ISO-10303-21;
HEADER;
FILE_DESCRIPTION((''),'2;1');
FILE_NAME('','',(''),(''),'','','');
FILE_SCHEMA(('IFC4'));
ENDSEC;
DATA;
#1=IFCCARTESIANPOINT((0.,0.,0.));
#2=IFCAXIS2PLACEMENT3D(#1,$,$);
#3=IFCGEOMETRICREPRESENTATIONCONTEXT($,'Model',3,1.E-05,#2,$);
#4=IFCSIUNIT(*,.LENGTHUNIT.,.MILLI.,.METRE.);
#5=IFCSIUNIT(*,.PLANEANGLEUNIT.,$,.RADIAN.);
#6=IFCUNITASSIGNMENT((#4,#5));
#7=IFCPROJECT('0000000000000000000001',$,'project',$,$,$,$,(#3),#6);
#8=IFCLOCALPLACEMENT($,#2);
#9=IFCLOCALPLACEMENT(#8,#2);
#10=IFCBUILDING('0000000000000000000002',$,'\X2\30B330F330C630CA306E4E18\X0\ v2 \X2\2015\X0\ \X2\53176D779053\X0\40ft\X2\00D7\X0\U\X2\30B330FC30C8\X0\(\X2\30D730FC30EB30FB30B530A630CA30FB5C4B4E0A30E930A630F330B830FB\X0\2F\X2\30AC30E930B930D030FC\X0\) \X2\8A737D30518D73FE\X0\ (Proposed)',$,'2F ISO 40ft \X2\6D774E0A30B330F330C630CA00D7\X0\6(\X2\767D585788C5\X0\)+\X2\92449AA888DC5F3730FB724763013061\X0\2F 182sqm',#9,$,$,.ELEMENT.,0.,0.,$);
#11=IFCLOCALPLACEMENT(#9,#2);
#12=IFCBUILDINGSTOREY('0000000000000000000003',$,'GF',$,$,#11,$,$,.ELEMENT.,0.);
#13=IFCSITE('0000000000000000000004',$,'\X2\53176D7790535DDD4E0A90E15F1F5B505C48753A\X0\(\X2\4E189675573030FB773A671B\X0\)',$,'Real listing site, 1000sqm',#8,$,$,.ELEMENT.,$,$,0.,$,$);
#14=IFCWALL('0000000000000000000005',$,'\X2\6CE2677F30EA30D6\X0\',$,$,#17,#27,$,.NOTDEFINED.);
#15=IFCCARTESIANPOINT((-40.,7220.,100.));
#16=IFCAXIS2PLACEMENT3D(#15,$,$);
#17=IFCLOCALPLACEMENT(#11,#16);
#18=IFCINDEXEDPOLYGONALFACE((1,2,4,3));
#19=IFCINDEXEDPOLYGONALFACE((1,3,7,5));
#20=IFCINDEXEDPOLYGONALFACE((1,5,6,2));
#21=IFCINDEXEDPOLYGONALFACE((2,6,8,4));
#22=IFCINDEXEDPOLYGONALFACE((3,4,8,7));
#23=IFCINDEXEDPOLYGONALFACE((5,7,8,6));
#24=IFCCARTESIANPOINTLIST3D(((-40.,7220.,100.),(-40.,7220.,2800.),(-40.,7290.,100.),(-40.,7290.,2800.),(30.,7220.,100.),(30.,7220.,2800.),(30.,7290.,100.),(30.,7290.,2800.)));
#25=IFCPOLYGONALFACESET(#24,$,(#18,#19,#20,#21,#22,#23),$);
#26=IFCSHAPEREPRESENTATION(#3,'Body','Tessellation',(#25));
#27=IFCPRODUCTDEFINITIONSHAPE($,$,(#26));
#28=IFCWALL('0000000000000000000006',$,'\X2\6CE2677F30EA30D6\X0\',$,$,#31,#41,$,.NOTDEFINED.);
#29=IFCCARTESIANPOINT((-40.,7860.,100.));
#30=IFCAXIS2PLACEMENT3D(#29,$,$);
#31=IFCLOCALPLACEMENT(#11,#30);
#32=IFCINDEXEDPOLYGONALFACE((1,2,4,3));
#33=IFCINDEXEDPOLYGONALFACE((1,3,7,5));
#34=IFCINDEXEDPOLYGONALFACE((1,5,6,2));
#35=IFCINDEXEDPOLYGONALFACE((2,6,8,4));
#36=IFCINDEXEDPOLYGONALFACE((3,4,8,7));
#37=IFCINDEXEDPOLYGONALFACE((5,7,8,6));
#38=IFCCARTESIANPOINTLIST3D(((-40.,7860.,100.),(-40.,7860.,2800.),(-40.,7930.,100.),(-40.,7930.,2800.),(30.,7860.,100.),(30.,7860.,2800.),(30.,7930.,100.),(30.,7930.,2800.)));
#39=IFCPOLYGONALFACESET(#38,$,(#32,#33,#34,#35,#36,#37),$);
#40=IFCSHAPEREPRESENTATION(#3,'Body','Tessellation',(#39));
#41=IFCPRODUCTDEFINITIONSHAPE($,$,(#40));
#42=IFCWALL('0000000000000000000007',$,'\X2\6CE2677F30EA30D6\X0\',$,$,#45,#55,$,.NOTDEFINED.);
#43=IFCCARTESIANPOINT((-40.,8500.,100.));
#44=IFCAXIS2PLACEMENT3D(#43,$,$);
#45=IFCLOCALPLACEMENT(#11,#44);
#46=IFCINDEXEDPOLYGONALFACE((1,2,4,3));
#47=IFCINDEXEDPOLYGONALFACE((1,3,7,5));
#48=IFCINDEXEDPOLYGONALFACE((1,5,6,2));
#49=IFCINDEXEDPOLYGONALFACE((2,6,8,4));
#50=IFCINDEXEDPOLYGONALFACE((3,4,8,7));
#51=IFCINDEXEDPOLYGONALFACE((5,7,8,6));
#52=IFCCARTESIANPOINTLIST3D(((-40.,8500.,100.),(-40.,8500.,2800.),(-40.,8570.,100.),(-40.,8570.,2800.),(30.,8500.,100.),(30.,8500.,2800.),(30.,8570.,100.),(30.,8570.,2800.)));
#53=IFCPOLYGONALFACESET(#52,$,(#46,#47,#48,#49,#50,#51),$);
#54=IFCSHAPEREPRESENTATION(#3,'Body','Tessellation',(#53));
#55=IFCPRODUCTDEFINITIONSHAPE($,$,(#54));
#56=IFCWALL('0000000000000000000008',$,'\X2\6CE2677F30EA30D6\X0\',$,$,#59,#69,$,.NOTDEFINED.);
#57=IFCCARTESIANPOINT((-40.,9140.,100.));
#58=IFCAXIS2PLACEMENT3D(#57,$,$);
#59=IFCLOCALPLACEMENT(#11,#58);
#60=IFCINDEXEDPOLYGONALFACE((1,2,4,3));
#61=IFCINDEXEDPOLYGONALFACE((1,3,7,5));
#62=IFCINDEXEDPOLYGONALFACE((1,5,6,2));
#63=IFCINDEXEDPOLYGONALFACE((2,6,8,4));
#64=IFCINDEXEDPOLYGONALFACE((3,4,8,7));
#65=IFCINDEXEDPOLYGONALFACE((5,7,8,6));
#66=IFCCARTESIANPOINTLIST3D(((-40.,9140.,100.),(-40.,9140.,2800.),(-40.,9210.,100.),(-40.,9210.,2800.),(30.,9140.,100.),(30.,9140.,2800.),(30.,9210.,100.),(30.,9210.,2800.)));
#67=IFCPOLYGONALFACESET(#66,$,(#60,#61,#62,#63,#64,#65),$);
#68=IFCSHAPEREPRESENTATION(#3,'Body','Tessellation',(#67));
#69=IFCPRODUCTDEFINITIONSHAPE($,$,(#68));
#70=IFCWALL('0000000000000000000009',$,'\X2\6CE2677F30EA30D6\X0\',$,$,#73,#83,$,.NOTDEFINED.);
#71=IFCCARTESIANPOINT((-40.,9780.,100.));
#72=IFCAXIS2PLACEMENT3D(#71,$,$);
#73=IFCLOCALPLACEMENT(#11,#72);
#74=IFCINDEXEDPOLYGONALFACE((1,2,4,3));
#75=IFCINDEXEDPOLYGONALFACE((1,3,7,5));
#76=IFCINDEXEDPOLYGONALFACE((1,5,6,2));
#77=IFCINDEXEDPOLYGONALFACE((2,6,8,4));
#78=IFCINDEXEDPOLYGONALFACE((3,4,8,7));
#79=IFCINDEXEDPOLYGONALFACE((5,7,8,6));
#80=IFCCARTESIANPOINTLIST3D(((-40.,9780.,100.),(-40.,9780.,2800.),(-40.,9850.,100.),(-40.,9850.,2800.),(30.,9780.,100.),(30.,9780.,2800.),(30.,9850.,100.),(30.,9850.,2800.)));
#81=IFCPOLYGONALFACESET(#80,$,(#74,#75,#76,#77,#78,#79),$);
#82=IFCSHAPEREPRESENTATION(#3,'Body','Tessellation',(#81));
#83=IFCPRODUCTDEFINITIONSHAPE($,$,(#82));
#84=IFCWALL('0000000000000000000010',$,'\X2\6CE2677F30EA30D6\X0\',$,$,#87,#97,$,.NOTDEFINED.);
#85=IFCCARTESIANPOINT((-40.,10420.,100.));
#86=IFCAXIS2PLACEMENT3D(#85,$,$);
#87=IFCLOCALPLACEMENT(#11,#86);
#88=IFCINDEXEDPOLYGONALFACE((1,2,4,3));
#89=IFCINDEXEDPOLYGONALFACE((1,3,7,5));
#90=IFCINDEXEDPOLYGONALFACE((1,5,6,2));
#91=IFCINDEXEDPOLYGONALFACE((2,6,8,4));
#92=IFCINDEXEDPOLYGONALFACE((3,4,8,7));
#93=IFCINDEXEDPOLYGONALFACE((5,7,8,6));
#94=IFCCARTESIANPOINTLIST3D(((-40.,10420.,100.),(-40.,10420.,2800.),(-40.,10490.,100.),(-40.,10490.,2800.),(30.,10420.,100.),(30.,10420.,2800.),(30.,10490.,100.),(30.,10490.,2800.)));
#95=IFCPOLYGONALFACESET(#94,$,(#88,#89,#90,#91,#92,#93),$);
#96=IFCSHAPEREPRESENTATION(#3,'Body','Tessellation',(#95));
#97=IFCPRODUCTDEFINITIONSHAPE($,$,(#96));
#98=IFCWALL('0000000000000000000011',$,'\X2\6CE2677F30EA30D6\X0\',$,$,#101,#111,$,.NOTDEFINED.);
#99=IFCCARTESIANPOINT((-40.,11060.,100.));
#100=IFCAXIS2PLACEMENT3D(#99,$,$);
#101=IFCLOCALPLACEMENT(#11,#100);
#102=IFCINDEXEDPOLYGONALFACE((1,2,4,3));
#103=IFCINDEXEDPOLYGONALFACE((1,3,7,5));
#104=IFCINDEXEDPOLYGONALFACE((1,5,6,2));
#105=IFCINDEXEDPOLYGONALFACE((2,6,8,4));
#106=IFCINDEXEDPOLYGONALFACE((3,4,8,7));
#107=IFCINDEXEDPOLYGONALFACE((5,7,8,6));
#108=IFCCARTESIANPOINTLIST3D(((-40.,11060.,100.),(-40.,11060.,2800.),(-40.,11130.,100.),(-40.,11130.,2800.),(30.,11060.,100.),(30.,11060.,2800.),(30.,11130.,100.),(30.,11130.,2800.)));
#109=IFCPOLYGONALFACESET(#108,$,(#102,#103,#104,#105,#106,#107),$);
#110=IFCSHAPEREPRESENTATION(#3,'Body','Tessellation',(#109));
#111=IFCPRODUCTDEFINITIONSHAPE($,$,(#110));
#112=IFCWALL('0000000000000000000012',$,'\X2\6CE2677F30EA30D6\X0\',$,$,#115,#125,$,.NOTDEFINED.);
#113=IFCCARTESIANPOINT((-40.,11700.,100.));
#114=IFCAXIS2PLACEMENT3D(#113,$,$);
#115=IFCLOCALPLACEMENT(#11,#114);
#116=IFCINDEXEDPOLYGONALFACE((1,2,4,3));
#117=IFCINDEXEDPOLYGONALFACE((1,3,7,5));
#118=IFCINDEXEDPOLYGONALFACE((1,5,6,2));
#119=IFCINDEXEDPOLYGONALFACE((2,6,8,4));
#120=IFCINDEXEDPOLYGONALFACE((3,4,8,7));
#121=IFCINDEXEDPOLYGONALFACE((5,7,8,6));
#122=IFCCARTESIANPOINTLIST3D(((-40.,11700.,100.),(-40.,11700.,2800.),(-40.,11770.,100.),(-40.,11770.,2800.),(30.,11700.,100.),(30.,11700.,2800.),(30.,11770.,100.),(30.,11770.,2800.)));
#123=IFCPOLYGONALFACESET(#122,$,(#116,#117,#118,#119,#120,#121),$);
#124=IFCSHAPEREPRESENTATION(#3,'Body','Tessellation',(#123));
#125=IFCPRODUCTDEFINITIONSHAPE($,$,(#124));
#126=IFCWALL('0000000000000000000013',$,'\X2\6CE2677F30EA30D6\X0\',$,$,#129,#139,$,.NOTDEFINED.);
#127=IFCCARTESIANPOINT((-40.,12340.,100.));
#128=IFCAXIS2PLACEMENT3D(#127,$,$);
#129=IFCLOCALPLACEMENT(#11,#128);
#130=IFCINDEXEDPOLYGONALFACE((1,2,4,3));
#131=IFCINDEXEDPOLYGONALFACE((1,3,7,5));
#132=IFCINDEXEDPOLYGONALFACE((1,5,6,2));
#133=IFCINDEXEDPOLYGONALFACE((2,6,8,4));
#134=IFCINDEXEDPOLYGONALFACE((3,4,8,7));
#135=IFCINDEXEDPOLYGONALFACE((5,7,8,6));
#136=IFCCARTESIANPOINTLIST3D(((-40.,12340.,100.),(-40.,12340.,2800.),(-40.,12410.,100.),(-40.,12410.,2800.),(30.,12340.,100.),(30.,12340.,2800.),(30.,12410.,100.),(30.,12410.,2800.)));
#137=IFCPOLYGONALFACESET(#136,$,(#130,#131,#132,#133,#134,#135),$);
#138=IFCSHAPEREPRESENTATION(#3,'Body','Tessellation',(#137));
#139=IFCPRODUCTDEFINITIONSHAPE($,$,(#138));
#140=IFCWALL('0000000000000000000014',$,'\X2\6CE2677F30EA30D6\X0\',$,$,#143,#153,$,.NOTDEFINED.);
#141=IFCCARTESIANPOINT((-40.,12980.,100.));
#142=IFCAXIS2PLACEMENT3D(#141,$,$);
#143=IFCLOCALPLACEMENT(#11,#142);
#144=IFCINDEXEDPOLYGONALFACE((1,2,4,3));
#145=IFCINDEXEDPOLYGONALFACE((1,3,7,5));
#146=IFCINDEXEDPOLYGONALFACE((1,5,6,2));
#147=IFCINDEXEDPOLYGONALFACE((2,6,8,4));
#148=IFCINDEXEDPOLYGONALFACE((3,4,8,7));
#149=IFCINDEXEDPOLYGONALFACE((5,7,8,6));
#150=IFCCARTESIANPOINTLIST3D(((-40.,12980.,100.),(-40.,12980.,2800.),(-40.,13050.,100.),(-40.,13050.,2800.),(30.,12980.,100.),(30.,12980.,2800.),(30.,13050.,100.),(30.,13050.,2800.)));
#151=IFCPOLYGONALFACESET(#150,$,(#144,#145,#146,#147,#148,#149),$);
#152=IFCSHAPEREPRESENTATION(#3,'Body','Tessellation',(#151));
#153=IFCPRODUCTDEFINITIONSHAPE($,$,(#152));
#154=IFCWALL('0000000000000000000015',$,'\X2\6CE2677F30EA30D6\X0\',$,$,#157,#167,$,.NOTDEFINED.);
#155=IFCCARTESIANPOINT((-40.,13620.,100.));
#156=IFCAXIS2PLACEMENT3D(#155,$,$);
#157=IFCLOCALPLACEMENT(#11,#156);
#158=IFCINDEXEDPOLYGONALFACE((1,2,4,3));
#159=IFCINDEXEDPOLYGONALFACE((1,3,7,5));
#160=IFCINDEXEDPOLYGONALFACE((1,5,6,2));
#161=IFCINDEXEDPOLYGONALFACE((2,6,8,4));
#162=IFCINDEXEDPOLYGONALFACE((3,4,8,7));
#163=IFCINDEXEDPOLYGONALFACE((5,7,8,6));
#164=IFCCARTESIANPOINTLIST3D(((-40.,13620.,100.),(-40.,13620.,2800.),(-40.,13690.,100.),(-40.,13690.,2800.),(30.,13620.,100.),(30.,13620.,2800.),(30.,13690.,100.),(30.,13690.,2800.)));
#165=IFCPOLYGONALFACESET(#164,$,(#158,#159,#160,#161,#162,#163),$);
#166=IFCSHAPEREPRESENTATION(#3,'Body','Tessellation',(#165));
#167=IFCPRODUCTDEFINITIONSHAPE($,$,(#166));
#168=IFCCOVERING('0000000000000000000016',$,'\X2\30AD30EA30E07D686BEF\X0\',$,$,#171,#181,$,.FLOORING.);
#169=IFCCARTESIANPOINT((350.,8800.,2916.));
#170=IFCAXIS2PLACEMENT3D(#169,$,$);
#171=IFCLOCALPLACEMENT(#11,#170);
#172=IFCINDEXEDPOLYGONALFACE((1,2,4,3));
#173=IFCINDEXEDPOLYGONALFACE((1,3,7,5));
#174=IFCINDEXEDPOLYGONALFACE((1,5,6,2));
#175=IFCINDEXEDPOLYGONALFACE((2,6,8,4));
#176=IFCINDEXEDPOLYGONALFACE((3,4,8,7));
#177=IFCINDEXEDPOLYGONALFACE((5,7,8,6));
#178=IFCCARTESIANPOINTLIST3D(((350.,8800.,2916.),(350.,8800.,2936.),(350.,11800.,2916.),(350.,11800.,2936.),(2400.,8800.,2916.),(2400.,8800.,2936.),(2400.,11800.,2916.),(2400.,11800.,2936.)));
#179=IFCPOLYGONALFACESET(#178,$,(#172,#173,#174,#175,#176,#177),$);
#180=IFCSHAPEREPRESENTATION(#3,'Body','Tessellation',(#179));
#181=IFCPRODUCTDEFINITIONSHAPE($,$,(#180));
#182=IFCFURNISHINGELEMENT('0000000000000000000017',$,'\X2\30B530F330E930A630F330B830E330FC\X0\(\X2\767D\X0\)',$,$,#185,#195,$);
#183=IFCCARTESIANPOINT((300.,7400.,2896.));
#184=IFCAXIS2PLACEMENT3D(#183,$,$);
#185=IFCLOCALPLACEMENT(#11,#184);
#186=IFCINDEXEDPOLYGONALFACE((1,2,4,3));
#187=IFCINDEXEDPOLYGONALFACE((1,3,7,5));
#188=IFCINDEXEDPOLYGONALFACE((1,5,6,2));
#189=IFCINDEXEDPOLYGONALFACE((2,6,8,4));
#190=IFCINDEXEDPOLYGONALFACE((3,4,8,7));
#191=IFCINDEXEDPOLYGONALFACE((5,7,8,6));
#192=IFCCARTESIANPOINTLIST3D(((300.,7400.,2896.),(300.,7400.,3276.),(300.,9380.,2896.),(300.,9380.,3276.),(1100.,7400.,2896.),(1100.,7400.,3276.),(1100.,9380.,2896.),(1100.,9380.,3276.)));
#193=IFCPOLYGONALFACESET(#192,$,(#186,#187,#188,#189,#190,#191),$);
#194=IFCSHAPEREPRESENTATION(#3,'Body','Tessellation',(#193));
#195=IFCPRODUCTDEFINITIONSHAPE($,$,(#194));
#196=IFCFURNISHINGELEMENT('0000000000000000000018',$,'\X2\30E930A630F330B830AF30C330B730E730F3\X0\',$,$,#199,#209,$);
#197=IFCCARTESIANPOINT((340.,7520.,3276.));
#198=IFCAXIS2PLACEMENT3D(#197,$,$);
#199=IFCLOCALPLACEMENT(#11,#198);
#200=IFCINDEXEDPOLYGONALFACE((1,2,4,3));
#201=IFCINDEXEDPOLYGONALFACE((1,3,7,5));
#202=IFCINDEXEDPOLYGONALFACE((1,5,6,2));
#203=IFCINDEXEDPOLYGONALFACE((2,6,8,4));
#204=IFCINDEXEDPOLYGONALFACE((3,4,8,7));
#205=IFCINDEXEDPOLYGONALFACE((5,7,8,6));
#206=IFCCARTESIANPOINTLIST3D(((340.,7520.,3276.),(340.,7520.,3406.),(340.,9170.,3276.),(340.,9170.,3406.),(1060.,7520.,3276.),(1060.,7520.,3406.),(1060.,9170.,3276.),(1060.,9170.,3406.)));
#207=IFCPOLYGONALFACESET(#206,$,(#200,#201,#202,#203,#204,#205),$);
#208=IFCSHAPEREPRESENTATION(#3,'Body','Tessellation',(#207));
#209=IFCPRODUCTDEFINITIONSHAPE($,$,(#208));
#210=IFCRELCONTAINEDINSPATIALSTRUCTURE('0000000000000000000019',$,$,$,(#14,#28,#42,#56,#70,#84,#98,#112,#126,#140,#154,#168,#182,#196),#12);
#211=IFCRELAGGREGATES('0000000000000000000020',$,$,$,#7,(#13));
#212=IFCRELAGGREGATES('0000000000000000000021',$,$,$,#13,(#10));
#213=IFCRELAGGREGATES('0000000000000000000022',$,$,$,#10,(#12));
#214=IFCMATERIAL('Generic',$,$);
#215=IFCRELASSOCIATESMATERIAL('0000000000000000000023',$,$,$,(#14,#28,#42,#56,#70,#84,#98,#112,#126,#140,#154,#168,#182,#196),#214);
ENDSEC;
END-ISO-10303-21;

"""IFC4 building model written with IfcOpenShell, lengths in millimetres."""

from ifc_helpers import new_model, si_unit, frame, frame_2d, origin, place, context, project, spatial, rectangle, extrude, material, element, save


model = new_model("IFC4")

# Units and contexts
model_context = context("Model", 3, precision=1e-05, world=origin())
ifc_project = project(units=[si_unit("LENGTHUNIT", "METRE", prefix="MILLI"), si_unit("PLANEANGLEUNIT", "RADIAN")], contexts=[model_context])

# Site, building, storey
site_placement = place(None, origin())
site = spatial("IfcSite", under=ifc_project, at=site_placement, Name="北海道川上郡弟子屈町(丘陵地・眺望)", ObjectType="Real listing site, 1000sqm", CompositionType="ELEMENT", RefElevation=0.0)
building_placement = place(site_placement, origin())
building = spatial("IfcBuilding", under=site, at=building_placement, Name="コンテナの丘 v2 ― 北海道40ft×Uコート(プール・サウナ・屋上ラウンジ・2Fガラスバー) 詳細再現 (Proposed)", ObjectType="2F ISO 40ft 海上コンテナ×6(白塗装)+鉄骨補強・片持ち2F 182sqm", CompositionType="ELEMENT", ElevationOfRefHeight=0.0, ElevationOfTerrain=0.0)
storey_placement = place(building_placement, origin())
storey = spatial("IfcBuildingStorey", under=building, at=storey_placement, Name="GF", CompositionType="ELEMENT", Elevation=0.0)

# Walls
ifc_material = material(Name="Generic")
wall_1_placement = place(storey_placement, frame((-40.0, 7220.0, 100.0)))
element("IfcWall", 1, at=wall_1_placement, inside=storey, material=ifc_material, Name="波板リブ", PredefinedType="NOTDEFINED", context=model_context, shape_type="SweptSolid", body=[
    extrude(rectangle(XDim=70.0, YDim=70.0, at=frame_2d((35.0, 35.0))), frame((-40.0, 7220.0, 100.0)), (0.0, 0.0, 1.0), 2700.0),
])
wall_2_placement = place(storey_placement, frame((-40.0, 7860.0, 100.0)))
element("IfcWall", 2, at=wall_2_placement, inside=storey, material=ifc_material, Name="波板リブ", PredefinedType="NOTDEFINED", context=model_context, shape_type="SweptSolid", body=[
    extrude(rectangle(XDim=70.0, YDim=70.0, at=frame_2d((35.0, 35.0))), frame((-40.0, 7860.0, 100.0)), (0.0, 0.0, 1.0), 2700.0),
])
wall_3_placement = place(storey_placement, frame((-40.0, 8500.0, 100.0)))
element("IfcWall", 3, at=wall_3_placement, inside=storey, material=ifc_material, Name="波板リブ", PredefinedType="NOTDEFINED", context=model_context, shape_type="SweptSolid", body=[
    extrude(rectangle(XDim=70.0, YDim=70.0, at=frame_2d((35.0, 35.0))), frame((-40.0, 8500.0, 100.0)), (0.0, 0.0, 1.0), 2700.0),
])
wall_4_placement = place(storey_placement, frame((-40.0, 9140.0, 100.0)))
element("IfcWall", 4, at=wall_4_placement, inside=storey, material=ifc_material, Name="波板リブ", PredefinedType="NOTDEFINED", context=model_context, shape_type="SweptSolid", body=[
    extrude(rectangle(XDim=70.0, YDim=70.0, at=frame_2d((35.0, 35.0))), frame((-40.0, 9140.0, 100.0)), (0.0, 0.0, 1.0), 2700.0),
])
wall_5_placement = place(storey_placement, frame((-40.0, 9780.0, 100.0)))
element("IfcWall", 5, at=wall_5_placement, inside=storey, material=ifc_material, Name="波板リブ", PredefinedType="NOTDEFINED", context=model_context, shape_type="SweptSolid", body=[
    extrude(rectangle(XDim=70.0, YDim=70.0, at=frame_2d((35.0, 35.0))), frame((-40.0, 9780.0, 100.0)), (0.0, 0.0, 1.0), 2700.0),
])
wall_6_placement = place(storey_placement, frame((-40.0, 10420.0, 100.0)))
element("IfcWall", 6, at=wall_6_placement, inside=storey, material=ifc_material, Name="波板リブ", PredefinedType="NOTDEFINED", context=model_context, shape_type="SweptSolid", body=[
    extrude(rectangle(XDim=70.0, YDim=70.0, at=frame_2d((35.0, 35.0))), frame((-40.0, 10420.0, 100.0)), (0.0, 0.0, 1.0), 2700.0),
])
wall_7_placement = place(storey_placement, frame((-40.0, 11060.0, 100.0)))
element("IfcWall", 7, at=wall_7_placement, inside=storey, material=ifc_material, Name="波板リブ", PredefinedType="NOTDEFINED", context=model_context, shape_type="SweptSolid", body=[
    extrude(rectangle(XDim=70.0, YDim=70.0, at=frame_2d((35.0, 35.0))), frame((-40.0, 11060.0, 100.0)), (0.0, 0.0, 1.0), 2700.0),
])
wall_8_placement = place(storey_placement, frame((-40.0, 11700.0, 100.0)))
element("IfcWall", 8, at=wall_8_placement, inside=storey, material=ifc_material, Name="波板リブ", PredefinedType="NOTDEFINED", context=model_context, shape_type="SweptSolid", body=[
    extrude(rectangle(XDim=70.0, YDim=70.0, at=frame_2d((35.0, 35.0))), frame((-40.0, 11700.0, 100.0)), (0.0, 0.0, 1.0), 2700.0),
])
wall_9_placement = place(storey_placement, frame((-40.0, 12340.0, 100.0)))
element("IfcWall", 9, at=wall_9_placement, inside=storey, material=ifc_material, Name="波板リブ", PredefinedType="NOTDEFINED", context=model_context, shape_type="SweptSolid", body=[
    extrude(rectangle(XDim=70.0, YDim=70.0, at=frame_2d((35.0, 35.0))), frame((-40.0, 12340.0, 100.0)), (0.0, 0.0, 1.0), 2700.0),
])
wall_10_placement = place(storey_placement, frame((-40.0, 12980.0, 100.0)))
element("IfcWall", 10, at=wall_10_placement, inside=storey, material=ifc_material, Name="波板リブ", PredefinedType="NOTDEFINED", context=model_context, shape_type="SweptSolid", body=[
    extrude(rectangle(XDim=70.0, YDim=70.0, at=frame_2d((35.0, 35.0))), frame((-40.0, 12980.0, 100.0)), (0.0, 0.0, 1.0), 2700.0),
])
wall_11_placement = place(storey_placement, frame((-40.0, 13620.0, 100.0)))
element("IfcWall", 11, at=wall_11_placement, inside=storey, material=ifc_material, Name="波板リブ", PredefinedType="NOTDEFINED", context=model_context, shape_type="SweptSolid", body=[
    extrude(rectangle(XDim=70.0, YDim=70.0, at=frame_2d((35.0, 35.0))), frame((-40.0, 13620.0, 100.0)), (0.0, 0.0, 1.0), 2700.0),
])

# Covering
covering_placement = place(storey_placement, frame((350.0, 8800.0, 2916.0)))
element("IfcCovering", 12, at=covering_placement, inside=storey, material=ifc_material, Name="キリム絨毯", PredefinedType="FLOORING", context=model_context, shape_type="SweptSolid", body=[
    extrude(rectangle(XDim=2050.0, YDim=3000.0, at=frame_2d((1025.0, 1500.0))), frame((350.0, 8800.0, 2916.0)), (0.0, 0.0, 1.0), 20.0),
])

# Furnishing elements
furnishing_1_placement = place(storey_placement, frame((300.0, 7400.0, 2896.0)))
element("IfcFurnishingElement", 13, at=furnishing_1_placement, inside=storey, material=ifc_material, Name="サンラウンジャー(白)", context=model_context, shape_type="SweptSolid", body=[
    extrude(rectangle(XDim=800.0, YDim=1980.0, at=frame_2d((400.0, 990.0))), frame((300.0, 7400.0, 2896.0)), (0.0, 0.0, 1.0), 380.0),
])
furnishing_2_placement = place(storey_placement, frame((340.0, 7520.0, 3276.0)))
element("IfcFurnishingElement", 14, at=furnishing_2_placement, inside=storey, material=ifc_material, Name="ラウンジクッション", context=model_context, shape_type="SweptSolid", body=[
    extrude(rectangle(XDim=720.0, YDim=1650.0, at=frame_2d((360.0, 825.0))), frame((340.0, 7520.0, 3276.0)), (0.0, 0.0, 1.0), 130.0),
])

save(model, "model.ifc")
